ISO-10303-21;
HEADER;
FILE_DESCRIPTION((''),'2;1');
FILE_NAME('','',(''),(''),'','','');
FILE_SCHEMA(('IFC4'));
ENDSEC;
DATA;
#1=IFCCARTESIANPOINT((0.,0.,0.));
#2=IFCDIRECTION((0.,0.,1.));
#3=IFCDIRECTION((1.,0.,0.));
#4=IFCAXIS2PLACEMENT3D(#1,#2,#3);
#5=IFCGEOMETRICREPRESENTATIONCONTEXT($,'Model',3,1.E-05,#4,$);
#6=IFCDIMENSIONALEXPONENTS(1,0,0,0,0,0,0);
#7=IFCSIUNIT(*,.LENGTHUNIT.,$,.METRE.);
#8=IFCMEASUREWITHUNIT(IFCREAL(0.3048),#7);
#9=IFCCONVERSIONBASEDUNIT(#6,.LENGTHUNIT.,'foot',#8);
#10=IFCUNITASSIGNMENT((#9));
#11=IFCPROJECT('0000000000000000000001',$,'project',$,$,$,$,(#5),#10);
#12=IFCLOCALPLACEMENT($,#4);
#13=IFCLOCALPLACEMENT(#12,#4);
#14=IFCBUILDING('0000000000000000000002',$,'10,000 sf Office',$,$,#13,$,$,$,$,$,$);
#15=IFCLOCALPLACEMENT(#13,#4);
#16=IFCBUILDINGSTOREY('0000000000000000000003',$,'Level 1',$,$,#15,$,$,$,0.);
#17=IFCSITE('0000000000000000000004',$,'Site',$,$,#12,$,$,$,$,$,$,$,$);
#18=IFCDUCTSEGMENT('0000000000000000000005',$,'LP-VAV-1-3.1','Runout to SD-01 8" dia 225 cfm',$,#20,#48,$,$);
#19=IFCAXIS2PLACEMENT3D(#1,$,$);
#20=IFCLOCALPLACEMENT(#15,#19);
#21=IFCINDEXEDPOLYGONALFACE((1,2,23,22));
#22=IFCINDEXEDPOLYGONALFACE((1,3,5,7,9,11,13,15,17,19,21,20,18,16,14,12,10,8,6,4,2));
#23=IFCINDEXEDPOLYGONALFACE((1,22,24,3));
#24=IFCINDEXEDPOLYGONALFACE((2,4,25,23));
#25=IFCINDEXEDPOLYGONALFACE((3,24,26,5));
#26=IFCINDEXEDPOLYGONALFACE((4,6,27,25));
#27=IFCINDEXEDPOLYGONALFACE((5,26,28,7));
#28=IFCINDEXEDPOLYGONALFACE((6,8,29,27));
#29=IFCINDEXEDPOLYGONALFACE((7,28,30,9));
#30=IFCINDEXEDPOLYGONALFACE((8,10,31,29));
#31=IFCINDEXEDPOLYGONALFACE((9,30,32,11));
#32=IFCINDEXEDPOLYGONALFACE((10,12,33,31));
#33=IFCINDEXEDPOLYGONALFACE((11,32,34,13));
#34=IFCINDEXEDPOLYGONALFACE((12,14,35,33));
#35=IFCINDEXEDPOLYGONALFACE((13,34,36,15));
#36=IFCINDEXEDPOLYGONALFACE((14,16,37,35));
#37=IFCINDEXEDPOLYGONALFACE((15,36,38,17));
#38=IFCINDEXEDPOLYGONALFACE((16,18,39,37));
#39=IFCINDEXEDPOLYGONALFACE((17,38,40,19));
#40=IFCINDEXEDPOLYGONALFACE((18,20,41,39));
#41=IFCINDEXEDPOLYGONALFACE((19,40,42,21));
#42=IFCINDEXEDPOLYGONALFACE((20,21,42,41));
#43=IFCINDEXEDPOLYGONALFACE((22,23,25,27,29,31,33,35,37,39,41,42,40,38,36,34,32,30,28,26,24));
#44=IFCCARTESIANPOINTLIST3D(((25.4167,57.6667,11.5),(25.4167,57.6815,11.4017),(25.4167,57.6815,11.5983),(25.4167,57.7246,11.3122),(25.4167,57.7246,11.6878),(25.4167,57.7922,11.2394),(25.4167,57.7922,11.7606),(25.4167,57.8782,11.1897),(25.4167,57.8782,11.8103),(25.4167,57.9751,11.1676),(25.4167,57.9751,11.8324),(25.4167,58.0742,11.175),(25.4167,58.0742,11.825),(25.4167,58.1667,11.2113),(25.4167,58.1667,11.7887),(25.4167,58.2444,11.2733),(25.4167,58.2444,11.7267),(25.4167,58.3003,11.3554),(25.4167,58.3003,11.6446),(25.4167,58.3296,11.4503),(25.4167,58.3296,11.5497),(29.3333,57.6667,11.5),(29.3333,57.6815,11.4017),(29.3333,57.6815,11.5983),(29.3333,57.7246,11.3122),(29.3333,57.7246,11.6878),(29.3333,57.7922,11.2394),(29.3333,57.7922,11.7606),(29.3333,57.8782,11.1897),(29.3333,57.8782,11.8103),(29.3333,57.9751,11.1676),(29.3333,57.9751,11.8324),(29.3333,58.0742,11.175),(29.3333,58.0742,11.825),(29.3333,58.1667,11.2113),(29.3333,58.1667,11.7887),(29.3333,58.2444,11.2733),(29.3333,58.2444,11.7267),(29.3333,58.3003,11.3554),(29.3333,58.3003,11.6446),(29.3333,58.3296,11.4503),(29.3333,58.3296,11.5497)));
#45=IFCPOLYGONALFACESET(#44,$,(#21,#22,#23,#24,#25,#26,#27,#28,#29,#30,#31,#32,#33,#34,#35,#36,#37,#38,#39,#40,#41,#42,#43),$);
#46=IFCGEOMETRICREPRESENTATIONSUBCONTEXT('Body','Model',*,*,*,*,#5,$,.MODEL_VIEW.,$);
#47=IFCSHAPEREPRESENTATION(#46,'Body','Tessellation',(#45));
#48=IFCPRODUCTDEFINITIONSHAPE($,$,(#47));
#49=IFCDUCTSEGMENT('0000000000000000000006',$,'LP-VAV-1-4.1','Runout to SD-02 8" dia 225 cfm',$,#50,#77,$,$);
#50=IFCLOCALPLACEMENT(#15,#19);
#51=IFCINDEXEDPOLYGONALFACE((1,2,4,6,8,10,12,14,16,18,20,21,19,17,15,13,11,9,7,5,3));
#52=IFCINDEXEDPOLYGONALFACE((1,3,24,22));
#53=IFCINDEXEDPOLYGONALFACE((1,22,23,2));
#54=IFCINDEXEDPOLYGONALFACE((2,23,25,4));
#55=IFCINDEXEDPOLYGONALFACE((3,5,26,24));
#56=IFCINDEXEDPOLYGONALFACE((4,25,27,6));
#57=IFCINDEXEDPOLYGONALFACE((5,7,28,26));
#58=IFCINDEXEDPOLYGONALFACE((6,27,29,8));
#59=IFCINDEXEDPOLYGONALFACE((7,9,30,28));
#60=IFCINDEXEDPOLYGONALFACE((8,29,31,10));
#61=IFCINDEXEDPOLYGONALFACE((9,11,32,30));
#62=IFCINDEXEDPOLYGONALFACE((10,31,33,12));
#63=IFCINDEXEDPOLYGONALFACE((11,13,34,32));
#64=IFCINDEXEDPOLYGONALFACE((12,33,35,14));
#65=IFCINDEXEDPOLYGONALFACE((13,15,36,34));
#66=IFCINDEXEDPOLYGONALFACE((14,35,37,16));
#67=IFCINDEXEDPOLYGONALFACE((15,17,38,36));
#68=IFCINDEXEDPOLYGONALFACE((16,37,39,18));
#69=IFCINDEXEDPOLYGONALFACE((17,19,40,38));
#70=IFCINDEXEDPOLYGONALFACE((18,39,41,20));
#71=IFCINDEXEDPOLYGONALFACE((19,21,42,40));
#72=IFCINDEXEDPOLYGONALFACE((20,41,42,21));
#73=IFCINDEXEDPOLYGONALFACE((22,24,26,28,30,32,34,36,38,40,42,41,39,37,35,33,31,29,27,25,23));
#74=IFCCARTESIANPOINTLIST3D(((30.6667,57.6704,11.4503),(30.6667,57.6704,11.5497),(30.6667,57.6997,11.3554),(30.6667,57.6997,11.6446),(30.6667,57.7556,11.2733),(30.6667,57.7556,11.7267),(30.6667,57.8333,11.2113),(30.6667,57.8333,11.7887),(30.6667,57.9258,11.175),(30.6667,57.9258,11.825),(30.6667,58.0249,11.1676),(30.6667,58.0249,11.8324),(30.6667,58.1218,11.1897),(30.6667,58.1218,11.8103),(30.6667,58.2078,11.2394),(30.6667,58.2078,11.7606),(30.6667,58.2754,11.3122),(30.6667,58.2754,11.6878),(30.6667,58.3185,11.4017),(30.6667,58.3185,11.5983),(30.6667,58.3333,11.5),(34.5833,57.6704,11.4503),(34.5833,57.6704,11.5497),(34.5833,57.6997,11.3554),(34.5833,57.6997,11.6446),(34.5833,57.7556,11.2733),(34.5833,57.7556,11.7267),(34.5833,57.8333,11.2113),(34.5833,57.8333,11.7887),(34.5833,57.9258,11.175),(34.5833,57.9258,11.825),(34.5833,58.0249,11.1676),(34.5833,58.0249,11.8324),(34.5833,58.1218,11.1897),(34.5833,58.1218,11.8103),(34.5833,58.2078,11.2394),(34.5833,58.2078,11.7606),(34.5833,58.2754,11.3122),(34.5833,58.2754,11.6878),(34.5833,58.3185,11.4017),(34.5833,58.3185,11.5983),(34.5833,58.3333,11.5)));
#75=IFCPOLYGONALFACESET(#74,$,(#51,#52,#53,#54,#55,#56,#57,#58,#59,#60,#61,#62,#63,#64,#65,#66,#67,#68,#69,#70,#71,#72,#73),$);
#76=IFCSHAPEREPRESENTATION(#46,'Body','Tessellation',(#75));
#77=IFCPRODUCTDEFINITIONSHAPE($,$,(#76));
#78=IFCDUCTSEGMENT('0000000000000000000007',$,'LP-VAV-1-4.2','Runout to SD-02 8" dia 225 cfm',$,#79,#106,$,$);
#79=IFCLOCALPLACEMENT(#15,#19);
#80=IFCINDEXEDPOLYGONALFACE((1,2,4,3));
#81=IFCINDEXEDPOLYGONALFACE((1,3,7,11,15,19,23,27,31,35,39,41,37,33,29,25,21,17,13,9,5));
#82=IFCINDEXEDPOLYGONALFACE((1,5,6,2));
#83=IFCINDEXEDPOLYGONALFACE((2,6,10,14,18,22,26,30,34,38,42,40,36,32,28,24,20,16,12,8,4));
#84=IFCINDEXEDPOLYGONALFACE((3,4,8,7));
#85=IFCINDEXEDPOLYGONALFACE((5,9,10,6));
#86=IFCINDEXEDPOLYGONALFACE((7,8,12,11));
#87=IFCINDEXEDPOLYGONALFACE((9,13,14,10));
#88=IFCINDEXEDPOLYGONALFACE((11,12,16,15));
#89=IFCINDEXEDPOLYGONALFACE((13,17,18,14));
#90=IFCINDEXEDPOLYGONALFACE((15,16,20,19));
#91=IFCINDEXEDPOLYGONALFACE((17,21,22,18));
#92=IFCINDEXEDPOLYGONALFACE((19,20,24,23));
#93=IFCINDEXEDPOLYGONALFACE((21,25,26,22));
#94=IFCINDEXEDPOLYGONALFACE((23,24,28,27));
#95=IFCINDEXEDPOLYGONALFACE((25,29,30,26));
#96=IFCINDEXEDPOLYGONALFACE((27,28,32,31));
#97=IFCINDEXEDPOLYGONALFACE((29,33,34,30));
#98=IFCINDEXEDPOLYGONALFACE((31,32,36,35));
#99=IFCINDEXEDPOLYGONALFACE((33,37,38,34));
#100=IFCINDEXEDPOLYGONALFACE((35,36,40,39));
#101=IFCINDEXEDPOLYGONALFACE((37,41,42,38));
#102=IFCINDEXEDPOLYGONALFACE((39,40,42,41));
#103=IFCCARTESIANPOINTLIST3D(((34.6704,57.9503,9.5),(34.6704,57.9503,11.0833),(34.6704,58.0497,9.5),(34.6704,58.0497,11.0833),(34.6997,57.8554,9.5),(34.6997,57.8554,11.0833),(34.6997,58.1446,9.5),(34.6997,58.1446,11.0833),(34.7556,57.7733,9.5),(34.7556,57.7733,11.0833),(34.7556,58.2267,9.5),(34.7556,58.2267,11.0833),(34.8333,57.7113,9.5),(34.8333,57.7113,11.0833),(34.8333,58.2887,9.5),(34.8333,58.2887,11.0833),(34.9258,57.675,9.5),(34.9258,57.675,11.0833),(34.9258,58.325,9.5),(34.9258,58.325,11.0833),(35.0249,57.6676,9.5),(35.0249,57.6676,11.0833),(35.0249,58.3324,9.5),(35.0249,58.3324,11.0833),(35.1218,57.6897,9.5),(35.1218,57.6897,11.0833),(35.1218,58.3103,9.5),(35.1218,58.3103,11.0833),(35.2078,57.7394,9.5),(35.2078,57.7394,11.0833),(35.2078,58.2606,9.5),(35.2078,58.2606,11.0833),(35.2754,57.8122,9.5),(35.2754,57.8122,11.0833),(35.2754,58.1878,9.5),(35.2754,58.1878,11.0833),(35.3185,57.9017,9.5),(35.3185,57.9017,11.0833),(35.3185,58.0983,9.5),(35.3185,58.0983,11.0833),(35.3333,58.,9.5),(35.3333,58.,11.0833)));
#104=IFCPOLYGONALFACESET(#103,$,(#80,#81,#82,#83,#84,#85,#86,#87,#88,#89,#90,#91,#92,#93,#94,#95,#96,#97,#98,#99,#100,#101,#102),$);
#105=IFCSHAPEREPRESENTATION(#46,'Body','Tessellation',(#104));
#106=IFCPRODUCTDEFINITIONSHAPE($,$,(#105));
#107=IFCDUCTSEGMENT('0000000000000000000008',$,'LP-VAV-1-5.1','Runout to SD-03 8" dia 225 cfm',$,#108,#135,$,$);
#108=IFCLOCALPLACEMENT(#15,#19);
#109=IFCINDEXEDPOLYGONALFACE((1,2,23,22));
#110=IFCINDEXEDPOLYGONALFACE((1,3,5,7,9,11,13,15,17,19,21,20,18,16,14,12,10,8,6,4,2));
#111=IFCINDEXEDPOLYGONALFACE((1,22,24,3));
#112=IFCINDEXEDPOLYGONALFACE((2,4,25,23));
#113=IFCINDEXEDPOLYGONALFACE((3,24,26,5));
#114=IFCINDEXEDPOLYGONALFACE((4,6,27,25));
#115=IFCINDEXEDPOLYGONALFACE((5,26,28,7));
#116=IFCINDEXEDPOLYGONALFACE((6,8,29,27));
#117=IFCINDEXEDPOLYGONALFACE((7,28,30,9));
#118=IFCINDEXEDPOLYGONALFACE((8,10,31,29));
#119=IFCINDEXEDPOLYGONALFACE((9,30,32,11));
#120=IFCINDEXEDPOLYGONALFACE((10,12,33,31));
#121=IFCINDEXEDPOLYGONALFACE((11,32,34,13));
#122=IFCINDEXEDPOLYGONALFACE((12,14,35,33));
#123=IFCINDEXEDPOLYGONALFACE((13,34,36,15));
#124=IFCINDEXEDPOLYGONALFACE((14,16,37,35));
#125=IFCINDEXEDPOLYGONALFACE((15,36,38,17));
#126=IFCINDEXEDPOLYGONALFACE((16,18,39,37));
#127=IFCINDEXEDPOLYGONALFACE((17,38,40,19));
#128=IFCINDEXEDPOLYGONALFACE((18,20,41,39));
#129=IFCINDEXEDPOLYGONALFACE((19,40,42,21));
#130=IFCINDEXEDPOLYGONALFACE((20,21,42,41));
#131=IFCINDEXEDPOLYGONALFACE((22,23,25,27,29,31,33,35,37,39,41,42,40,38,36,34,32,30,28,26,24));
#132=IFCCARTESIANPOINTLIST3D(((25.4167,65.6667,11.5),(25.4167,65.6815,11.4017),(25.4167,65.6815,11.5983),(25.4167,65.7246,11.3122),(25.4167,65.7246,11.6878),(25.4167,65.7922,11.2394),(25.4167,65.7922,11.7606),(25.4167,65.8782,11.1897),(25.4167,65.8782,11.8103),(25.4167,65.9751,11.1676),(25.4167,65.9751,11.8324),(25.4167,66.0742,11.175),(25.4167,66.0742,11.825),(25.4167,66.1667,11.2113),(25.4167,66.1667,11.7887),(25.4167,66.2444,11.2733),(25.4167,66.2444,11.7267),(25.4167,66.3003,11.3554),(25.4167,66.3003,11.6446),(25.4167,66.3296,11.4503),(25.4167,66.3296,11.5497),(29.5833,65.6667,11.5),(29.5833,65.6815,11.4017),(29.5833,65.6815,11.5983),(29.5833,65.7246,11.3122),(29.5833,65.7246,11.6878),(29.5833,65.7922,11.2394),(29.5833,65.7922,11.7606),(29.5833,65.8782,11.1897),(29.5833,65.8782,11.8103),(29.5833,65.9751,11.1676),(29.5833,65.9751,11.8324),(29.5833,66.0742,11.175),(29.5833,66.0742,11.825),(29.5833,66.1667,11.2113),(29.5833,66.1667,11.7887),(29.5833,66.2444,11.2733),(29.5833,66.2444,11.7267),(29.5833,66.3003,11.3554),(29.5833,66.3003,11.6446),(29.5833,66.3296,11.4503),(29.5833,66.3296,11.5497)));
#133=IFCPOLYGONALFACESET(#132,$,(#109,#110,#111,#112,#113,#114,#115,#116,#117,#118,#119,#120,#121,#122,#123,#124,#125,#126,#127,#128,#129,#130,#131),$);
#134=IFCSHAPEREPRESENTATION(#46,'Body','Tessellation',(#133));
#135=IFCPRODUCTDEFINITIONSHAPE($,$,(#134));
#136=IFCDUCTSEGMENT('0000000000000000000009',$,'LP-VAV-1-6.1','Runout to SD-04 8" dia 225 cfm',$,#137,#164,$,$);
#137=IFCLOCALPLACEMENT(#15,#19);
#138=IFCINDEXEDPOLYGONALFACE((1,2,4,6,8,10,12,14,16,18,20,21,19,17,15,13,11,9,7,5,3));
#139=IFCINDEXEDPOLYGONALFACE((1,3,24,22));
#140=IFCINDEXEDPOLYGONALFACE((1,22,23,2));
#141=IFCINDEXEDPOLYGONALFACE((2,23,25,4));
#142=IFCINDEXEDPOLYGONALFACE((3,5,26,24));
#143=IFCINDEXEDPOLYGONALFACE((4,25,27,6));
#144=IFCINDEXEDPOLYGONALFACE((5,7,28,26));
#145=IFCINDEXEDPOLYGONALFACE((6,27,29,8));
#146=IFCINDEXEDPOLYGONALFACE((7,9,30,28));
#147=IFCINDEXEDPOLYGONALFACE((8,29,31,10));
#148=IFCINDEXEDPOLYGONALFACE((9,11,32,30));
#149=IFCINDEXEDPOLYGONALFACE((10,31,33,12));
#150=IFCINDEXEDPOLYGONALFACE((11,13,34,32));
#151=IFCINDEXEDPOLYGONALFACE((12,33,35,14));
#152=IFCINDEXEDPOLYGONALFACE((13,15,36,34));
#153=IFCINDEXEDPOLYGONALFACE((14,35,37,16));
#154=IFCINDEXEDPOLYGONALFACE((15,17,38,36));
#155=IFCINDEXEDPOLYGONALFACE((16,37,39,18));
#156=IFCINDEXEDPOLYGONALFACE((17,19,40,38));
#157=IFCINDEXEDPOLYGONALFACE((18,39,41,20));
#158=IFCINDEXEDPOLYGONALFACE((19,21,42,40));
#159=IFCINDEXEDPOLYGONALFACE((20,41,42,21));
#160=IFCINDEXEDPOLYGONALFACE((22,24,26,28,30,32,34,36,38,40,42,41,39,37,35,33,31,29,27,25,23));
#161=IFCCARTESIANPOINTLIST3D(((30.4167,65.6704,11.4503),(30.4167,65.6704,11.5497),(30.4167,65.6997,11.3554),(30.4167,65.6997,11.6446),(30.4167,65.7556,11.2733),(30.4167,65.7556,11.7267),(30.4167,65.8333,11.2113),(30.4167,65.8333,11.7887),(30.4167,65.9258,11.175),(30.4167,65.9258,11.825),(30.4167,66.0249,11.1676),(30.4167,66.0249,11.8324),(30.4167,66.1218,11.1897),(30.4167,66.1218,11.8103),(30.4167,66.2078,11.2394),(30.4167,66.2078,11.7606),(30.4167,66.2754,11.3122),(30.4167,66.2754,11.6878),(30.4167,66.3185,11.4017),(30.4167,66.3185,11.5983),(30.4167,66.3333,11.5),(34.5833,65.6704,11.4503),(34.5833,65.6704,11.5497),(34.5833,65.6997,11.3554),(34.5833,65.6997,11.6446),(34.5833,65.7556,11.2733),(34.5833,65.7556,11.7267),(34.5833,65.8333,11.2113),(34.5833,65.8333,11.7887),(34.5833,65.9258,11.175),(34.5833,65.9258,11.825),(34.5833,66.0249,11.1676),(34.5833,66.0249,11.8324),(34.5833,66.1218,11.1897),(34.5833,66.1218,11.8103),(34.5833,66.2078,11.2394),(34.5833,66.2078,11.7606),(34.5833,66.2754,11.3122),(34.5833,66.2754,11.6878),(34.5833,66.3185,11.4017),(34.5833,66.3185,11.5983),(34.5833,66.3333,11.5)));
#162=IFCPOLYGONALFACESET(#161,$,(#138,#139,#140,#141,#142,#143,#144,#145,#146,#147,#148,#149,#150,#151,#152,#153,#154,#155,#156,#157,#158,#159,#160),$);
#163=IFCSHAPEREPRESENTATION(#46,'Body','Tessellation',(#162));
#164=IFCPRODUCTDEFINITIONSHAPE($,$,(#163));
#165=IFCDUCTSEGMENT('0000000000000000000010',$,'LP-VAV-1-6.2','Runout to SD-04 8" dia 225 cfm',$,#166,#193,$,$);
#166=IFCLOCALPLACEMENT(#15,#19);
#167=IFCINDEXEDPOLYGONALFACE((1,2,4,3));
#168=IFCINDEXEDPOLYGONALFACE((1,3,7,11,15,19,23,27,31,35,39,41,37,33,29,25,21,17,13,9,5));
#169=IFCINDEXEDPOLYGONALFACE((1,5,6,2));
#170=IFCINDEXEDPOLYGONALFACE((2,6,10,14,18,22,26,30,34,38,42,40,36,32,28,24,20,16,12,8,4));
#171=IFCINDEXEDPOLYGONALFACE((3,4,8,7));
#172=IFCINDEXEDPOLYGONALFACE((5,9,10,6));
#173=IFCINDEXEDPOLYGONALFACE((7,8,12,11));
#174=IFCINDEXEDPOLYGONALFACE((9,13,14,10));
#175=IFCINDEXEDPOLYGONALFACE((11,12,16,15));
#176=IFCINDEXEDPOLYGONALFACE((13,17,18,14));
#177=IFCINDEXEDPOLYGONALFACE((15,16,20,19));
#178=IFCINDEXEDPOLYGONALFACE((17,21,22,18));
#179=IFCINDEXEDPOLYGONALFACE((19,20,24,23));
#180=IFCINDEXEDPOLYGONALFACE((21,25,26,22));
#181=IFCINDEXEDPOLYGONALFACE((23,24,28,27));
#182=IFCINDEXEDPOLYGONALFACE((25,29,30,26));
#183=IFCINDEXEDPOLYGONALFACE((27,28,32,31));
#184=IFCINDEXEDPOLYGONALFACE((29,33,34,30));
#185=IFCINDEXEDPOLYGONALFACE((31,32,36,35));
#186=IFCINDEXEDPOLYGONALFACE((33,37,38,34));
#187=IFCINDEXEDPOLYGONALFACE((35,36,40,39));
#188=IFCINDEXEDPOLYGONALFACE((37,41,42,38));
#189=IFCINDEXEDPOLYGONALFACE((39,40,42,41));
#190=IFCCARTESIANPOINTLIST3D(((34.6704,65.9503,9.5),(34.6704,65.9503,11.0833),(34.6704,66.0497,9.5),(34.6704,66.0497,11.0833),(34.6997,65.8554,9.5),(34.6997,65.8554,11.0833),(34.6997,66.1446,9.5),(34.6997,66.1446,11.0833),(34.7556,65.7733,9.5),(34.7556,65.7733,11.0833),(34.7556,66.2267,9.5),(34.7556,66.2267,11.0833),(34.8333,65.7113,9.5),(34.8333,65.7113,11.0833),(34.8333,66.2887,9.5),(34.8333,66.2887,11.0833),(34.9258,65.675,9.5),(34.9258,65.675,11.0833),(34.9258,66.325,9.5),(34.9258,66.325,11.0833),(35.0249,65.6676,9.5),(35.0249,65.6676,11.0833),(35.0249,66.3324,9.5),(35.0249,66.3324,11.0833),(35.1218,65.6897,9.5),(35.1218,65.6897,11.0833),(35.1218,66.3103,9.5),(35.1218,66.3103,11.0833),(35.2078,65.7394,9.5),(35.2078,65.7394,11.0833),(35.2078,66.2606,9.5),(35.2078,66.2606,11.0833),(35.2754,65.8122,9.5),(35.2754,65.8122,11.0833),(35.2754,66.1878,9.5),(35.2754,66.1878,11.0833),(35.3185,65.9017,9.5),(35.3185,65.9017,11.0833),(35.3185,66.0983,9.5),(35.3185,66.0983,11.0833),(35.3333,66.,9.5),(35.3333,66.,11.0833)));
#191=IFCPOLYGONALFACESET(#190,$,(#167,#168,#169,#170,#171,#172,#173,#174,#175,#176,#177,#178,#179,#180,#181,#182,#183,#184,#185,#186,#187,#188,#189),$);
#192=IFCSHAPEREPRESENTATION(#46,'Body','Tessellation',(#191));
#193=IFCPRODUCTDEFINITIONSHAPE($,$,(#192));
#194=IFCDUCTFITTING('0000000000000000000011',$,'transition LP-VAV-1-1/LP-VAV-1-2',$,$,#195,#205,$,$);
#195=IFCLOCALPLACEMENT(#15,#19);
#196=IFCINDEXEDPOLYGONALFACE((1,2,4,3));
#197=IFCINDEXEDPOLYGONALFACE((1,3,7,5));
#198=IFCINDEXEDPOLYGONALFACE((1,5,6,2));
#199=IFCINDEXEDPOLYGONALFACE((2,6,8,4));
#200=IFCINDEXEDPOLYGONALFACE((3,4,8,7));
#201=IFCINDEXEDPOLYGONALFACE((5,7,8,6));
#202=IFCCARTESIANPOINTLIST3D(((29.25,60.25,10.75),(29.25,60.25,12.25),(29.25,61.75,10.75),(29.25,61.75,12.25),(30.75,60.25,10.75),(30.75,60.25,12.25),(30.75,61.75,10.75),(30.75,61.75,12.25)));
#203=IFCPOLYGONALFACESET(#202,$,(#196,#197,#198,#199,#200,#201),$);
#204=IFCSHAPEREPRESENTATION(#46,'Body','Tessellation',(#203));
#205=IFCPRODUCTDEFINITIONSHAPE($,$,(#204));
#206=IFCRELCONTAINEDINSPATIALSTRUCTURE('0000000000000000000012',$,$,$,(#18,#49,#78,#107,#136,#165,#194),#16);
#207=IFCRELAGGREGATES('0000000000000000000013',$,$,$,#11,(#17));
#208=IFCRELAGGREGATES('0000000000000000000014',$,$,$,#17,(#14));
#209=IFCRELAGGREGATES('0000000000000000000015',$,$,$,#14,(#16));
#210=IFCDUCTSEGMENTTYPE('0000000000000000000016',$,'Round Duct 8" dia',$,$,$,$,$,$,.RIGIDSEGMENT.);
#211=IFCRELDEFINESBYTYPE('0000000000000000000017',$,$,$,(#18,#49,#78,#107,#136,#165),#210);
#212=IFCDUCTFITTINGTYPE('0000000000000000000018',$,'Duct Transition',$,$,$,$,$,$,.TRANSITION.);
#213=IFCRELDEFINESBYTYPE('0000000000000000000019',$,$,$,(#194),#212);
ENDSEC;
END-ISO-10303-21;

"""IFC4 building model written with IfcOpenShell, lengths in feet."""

from ifc_helpers import new_model, entity, si_unit, converted_unit, frame, origin_with_axes, place, context, subcontext, project, spatial, rectangle, circle, extrude, type_object, element, save


model = new_model("IFC4")

# Units and contexts
model_context = context("Model", 3, precision=1e-05, world=origin_with_axes())
body_context = subcontext(model_context, "Body", "Model", "MODEL_VIEW")
ifc_project = project(units=[converted_unit("LENGTHUNIT", "foot", entity("IfcReal", 0.3048), si_unit("LENGTHUNIT", "METRE"), dimensions=[1, 0, 0, 0, 0, 0, 0])], contexts=[model_context])

# Site, building, storey
site_placement = place(None, origin_with_axes())
site = spatial("IfcSite", under=ifc_project, at=site_placement, Name="Site")
building_placement = place(site_placement, origin_with_axes())
building = spatial("IfcBuilding", under=site, at=building_placement, Name="10,000 sf Office")
storey_placement = place(building_placement, origin_with_axes())
storey = spatial("IfcBuildingStorey", under=building, at=storey_placement, Name="Level 1", Elevation=0.0)

# Duct segments
duct_segment_type_1 = type_object("IfcDuctSegmentType", Name="Round Duct 8\" dia", PredefinedType="RIGIDSEGMENT")
duct_segment_1_placement = place(storey_placement, frame((29.3333, 58.0, 11.5), z_axis=(-1.0, 0.0, 0.0), x_axis=(0.0, -1.0, 0.0)))
element("IfcDuctSegment", 1, at=duct_segment_1_placement, inside=storey, type_object=duct_segment_type_1, Name="LP-VAV-1-3.1", Description="Runout to SD-01 8\" dia 225 cfm", context=body_context, shape_type="SweptSolid", body=[
    extrude(circle(Radius=0.3333), None, (0.0, 0.0, 1.0), 3.9167),
])
duct_segment_2_placement = place(storey_placement, frame((30.6667, 58.0, 11.5), z_axis=(1.0, 0.0, 0.0), x_axis=(0.0, 1.0, 0.0)))
element("IfcDuctSegment", 2, at=duct_segment_2_placement, inside=storey, type_object=duct_segment_type_1, Name="LP-VAV-1-4.1", Description="Runout to SD-02 8\" dia 225 cfm", context=body_context, shape_type="SweptSolid", body=[
    extrude(circle(Radius=0.3333), None, (0.0, 0.0, 1.0), 3.9167),
])
duct_segment_3_placement = place(storey_placement, frame((35.0, 58.0, 11.0833), z_axis=(0.0, 0.0, -1.0), x_axis=(1.0, 0.0, 0.0)))
element("IfcDuctSegment", 3, at=duct_segment_3_placement, inside=storey, type_object=duct_segment_type_1, Name="LP-VAV-1-4.2", Description="Runout to SD-02 8\" dia 225 cfm", context=body_context, shape_type="SweptSolid", body=[
    extrude(circle(Radius=0.3333), None, (0.0, 0.0, 1.0), 1.5833),
])
duct_segment_4_placement = place(storey_placement, frame((29.5833, 66.0, 11.5), z_axis=(-1.0, 0.0, 0.0), x_axis=(0.0, -1.0, 0.0)))
element("IfcDuctSegment", 4, at=duct_segment_4_placement, inside=storey, type_object=duct_segment_type_1, Name="LP-VAV-1-5.1", Description="Runout to SD-03 8\" dia 225 cfm", context=body_context, shape_type="SweptSolid", body=[
    extrude(circle(Radius=0.3333), None, (0.0, 0.0, 1.0), 4.1667),
])
duct_segment_5_placement = place(storey_placement, frame((30.4167, 66.0, 11.5), z_axis=(1.0, 0.0, 0.0), x_axis=(0.0, 1.0, 0.0)))
element("IfcDuctSegment", 5, at=duct_segment_5_placement, inside=storey, type_object=duct_segment_type_1, Name="LP-VAV-1-6.1", Description="Runout to SD-04 8\" dia 225 cfm", context=body_context, shape_type="SweptSolid", body=[
    extrude(circle(Radius=0.3333), None, (0.0, 0.0, 1.0), 4.1667),
])
duct_segment_6_placement = place(storey_placement, frame((35.0, 66.0, 11.0833), z_axis=(0.0, 0.0, -1.0), x_axis=(1.0, 0.0, 0.0)))
element("IfcDuctSegment", 6, at=duct_segment_6_placement, inside=storey, type_object=duct_segment_type_1, Name="LP-VAV-1-6.2", Description="Runout to SD-04 8\" dia 225 cfm", context=body_context, shape_type="SweptSolid", body=[
    extrude(circle(Radius=0.3333), None, (0.0, 0.0, 1.0), 1.5833),
])

# Duct fitting
duct_fitting_type_1 = type_object("IfcDuctFittingType", Name="Duct Transition", PredefinedType="TRANSITION")
duct_fitting_1_placement = place(storey_placement, frame((30.0, 61.0, 10.75), z_axis=(0.0, 0.0, 1.0), x_axis=(1.0, 0.0, 0.0)))
element("IfcDuctFitting", 7, at=duct_fitting_1_placement, inside=storey, type_object=duct_fitting_type_1, Name="transition LP-VAV-1-1/LP-VAV-1-2", context=body_context, shape_type="SweptSolid", body=[
    extrude(rectangle(XDim=1.5, YDim=1.5), None, (0.0, 0.0, 1.0), 1.5),
])

save(model, "model.ifc")
